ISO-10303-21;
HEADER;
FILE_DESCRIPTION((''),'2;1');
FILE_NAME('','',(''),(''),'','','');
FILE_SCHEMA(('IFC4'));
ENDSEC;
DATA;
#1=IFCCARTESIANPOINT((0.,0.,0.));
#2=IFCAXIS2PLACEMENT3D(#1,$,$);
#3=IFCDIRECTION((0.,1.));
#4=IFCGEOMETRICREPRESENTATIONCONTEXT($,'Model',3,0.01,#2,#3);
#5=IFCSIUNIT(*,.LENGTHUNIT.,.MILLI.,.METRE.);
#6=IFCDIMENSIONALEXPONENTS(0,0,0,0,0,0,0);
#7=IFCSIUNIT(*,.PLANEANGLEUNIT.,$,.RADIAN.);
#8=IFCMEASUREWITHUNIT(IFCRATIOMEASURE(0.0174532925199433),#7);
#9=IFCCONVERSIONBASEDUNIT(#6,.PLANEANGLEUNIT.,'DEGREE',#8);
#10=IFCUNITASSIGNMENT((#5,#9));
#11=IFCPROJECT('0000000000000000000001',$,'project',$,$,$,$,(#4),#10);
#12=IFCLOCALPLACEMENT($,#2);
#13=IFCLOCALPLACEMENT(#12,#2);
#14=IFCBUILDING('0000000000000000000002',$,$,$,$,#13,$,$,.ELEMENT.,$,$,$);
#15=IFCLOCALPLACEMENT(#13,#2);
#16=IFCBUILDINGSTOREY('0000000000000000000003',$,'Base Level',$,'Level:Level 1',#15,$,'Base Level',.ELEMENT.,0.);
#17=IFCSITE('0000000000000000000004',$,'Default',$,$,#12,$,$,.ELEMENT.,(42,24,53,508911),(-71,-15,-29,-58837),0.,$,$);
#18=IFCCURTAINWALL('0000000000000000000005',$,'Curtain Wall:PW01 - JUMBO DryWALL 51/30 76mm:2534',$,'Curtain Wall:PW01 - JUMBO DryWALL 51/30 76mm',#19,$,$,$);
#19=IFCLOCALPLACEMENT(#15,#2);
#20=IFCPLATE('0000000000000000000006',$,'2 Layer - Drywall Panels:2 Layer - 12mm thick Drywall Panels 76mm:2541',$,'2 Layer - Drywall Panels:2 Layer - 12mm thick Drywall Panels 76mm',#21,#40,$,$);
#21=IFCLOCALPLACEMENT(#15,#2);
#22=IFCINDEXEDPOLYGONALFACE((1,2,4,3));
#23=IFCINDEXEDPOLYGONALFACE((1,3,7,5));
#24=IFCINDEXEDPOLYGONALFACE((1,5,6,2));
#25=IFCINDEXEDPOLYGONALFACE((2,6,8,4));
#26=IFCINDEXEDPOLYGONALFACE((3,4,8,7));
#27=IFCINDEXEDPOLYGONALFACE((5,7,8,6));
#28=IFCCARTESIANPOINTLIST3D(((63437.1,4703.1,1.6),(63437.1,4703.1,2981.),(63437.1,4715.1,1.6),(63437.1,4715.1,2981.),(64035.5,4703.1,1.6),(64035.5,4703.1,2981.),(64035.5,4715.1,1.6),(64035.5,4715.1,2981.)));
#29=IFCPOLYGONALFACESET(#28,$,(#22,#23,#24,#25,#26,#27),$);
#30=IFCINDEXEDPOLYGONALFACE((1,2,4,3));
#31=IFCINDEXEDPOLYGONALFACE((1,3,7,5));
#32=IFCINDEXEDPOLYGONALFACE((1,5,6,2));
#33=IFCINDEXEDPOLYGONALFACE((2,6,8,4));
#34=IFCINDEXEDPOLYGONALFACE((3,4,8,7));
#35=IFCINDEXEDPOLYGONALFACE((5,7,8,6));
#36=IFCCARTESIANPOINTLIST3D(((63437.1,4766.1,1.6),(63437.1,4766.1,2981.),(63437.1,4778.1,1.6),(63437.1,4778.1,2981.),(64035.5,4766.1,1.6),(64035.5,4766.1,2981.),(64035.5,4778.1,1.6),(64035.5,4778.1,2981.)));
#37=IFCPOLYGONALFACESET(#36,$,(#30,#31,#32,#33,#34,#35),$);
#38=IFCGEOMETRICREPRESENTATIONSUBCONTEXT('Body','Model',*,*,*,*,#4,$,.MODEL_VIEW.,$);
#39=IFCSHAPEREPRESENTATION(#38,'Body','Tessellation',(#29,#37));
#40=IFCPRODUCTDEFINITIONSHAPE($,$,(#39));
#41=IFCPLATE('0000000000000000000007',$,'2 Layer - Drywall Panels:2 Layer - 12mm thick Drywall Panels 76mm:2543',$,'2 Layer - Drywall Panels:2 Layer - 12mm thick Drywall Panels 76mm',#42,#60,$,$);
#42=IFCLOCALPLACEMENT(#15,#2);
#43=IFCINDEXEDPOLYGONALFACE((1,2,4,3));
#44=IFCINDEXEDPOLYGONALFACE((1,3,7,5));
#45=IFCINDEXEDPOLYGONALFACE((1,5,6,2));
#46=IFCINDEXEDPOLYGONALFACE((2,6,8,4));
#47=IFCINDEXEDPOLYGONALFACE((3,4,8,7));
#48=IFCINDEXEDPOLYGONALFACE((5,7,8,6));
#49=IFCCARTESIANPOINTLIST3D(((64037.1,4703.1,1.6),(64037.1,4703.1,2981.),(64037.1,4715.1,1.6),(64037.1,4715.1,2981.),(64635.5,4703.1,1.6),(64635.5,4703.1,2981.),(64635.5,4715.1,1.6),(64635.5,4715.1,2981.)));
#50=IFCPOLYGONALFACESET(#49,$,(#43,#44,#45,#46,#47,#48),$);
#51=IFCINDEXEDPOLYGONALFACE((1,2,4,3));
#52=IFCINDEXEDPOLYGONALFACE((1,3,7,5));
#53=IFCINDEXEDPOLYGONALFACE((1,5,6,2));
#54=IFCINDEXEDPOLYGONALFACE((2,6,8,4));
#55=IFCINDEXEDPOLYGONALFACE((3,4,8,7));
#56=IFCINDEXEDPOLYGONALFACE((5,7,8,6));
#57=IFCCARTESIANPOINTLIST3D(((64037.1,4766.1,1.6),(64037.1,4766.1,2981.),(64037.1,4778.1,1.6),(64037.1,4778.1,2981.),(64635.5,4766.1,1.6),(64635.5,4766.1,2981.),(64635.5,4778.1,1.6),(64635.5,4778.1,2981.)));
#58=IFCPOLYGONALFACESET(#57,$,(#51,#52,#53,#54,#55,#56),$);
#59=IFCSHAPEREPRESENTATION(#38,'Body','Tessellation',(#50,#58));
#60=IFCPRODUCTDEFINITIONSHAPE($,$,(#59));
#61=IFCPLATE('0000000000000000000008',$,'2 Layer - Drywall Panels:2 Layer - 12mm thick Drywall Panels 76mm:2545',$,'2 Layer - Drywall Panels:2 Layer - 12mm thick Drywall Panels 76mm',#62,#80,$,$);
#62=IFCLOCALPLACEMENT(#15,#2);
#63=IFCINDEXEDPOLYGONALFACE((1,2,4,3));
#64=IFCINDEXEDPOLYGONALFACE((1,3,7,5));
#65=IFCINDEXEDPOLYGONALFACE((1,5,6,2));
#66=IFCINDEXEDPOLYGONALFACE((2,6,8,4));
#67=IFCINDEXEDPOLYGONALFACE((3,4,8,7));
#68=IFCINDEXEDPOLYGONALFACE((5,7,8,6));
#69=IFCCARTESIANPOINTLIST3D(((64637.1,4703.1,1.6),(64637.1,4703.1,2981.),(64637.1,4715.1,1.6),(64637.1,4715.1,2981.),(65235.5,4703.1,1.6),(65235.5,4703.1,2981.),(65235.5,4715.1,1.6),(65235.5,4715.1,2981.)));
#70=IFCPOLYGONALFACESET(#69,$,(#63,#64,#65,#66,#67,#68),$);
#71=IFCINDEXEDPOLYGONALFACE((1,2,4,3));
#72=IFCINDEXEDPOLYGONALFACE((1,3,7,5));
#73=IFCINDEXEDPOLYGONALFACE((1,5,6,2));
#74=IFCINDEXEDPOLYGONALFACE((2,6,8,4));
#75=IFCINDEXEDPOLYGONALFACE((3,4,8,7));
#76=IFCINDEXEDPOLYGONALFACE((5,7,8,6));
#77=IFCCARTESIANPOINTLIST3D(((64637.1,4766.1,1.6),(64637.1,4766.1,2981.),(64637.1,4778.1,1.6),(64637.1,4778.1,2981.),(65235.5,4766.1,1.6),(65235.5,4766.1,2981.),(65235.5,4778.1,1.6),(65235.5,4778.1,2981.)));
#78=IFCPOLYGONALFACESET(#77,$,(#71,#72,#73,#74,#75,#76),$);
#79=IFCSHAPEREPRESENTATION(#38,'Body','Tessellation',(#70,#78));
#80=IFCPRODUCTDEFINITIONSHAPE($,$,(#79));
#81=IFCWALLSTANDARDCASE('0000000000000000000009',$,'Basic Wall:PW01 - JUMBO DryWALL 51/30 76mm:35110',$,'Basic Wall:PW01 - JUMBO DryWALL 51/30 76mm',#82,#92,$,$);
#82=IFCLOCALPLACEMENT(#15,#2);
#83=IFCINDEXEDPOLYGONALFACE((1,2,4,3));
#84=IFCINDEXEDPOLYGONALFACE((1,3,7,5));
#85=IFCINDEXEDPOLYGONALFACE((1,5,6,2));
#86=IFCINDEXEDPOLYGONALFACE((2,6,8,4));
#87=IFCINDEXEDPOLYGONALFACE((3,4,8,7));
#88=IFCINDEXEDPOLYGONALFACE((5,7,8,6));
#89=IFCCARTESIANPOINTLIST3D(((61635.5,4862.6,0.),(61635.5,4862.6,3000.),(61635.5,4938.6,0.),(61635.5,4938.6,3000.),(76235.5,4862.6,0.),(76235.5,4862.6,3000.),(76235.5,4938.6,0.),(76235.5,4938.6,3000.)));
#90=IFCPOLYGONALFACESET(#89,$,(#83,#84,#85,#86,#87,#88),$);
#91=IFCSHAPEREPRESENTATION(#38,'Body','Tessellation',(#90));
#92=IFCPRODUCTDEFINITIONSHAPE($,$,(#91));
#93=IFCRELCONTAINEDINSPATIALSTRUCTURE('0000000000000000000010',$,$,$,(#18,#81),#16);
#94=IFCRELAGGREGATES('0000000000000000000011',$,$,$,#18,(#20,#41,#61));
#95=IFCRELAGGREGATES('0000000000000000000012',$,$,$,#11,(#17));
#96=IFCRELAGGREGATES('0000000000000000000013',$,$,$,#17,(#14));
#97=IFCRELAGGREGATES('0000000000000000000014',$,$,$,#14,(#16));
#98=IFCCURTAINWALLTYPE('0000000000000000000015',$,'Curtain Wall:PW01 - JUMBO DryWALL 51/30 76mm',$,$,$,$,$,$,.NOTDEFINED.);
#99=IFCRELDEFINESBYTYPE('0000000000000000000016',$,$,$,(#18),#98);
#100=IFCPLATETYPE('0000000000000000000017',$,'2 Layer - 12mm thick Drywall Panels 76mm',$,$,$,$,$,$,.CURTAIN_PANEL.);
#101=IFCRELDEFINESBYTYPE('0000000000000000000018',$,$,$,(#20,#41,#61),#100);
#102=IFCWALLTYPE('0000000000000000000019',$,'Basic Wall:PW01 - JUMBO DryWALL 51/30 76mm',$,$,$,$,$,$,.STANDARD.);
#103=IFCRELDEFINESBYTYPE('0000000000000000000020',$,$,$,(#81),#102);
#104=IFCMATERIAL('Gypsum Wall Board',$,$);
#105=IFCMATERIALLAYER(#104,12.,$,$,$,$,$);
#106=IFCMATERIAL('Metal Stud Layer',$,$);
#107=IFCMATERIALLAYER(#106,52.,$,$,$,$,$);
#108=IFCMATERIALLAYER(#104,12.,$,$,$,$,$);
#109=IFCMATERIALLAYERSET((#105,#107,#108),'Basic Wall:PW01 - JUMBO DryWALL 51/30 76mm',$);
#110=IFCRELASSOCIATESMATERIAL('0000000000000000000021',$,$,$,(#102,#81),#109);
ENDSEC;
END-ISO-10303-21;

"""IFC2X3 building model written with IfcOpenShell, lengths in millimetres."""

from ifc_helpers import new_model, entity, si_unit, converted_unit, direction, frame, frame_2d, origin, origin_2d_with_axis, place, context, subcontext, project, spatial, rectangle, extrude, source, transform, mapped, material, layer, layer_set, layer_usage, type_object, type_shapes, element, aggregate, save


model = new_model("IFC2X3")

# Units and contexts
model_context = context("Model", 3, precision=0.01, world=origin(), true_north=direction((0.0, 1.0)))
body_context = subcontext(model_context, "Body", "Model", "MODEL_VIEW")
ifc_project = project(units=[si_unit("LENGTHUNIT", "METRE", prefix="MILLI"), converted_unit("PLANEANGLEUNIT", "DEGREE", entity("IfcRatioMeasure", 0.0174532925199433), si_unit("PLANEANGLEUNIT", "RADIAN"), dimensions=[0, 0, 0, 0, 0, 0, 0])], contexts=[model_context])

# Site, building, storey
site_placement = place(None, origin())
site = spatial("IfcSite", under=ifc_project, at=site_placement, Name="Default", CompositionType="ELEMENT", RefLatitude=(42, 24, 53, 508911), RefLongitude=(-71, -15, -29, -58837), RefElevation=0.0)
building_placement = place(site_placement, origin())
building = spatial("IfcBuilding", under=site, at=building_placement, CompositionType="ELEMENT")
storey_placement = place(building_placement, origin())
storey = spatial("IfcBuildingStorey", under=building, at=storey_placement, Name="Base Level", ObjectType="Level:Level 1", LongName="Base Level", CompositionType="ELEMENT", Elevation=0.0)

# Curtain wall, plates
curtain_wall_type = type_object("IfcCurtainWallType", Name="Curtain Wall:PW01 - JUMBO DryWALL 51/30 76mm", PredefinedType="NOTDEFINED")
curtain_wall_placement = place(building_placement, origin())
curtain_wall = element("IfcCurtainWall", 1, at=curtain_wall_placement, inside=storey, type_object=curtain_wall_type, Name="Curtain Wall:PW01 - JUMBO DryWALL 51/30 76mm:2534", ObjectType="Curtain Wall:PW01 - JUMBO DryWALL 51/30 76mm")
plate_type = type_object("IfcPlateType", Name="2 Layer - 12mm thick Drywall Panels 76mm", PredefinedType="CURTAIN_PANEL")
shared_shape_1 = source(origin(), body_context, "Body", "SweptSolid", [
    extrude(rectangle(XDim=598.4, YDim=12.0, at=origin_2d_with_axis()), frame((0.0, -31.5, 0.0), z_axis=(0.0, 0.0, 1.0), x_axis=(-1.0, 0.0, 0.0)), (0.0, 0.0, 1.0), 2979.4),
    extrude(rectangle(XDim=12.0, YDim=598.4, at=frame_2d((0.0, 0.0), x_axis=(1.0, 0.0))), frame((0.0, 31.5, 0.0), z_axis=(0.0, 0.0, 1.0), x_axis=(0.0, 1.0, 0.0)), (0.0, 0.0, 1.0), 2979.4),
])
type_shapes(plate_type, [shared_shape_1])
plate_1_placement = place(curtain_wall_placement, frame((63736.3, 4740.6, 1.6)))
plate_1 = element("IfcPlate", 2, at=plate_1_placement, type_object=plate_type, Name="2 Layer - Drywall Panels:2 Layer - 12mm thick Drywall Panels 76mm:2541", ObjectType="2 Layer - Drywall Panels:2 Layer - 12mm thick Drywall Panels 76mm", context=body_context, shape_type="MappedRepresentation", body=[
    mapped(shared_shape_1, transform((0.0, 0.0, 0.0), scale=1.0)),
])
plate_2_placement = place(curtain_wall_placement, frame((64336.3, 4740.6, 1.6)))
plate_2 = element("IfcPlate", 3, at=plate_2_placement, type_object=plate_type, Name="2 Layer - Drywall Panels:2 Layer - 12mm thick Drywall Panels 76mm:2543", ObjectType="2 Layer - Drywall Panels:2 Layer - 12mm thick Drywall Panels 76mm", context=body_context, shape_type="MappedRepresentation", body=[
    mapped(shared_shape_1, transform((0.0, 0.0, 0.0), scale=1.0)),
])
plate_3_placement = place(curtain_wall_placement, frame((64936.3, 4740.6, 1.6)))
plate_3 = element("IfcPlate", 4, at=plate_3_placement, type_object=plate_type, Name="2 Layer - Drywall Panels:2 Layer - 12mm thick Drywall Panels 76mm:2545", ObjectType="2 Layer - Drywall Panels:2 Layer - 12mm thick Drywall Panels 76mm", context=body_context, shape_type="MappedRepresentation", body=[
    mapped(shared_shape_1, transform((0.0, 0.0, 0.0), scale=1.0)),
])
aggregate(curtain_wall, [plate_1, plate_2, plate_3])

# Wall
ifc_material_1 = material(Name="Gypsum Wall Board")
ifc_layer_1 = layer(ifc_material_1, 12.0)
ifc_material_2 = material(Name="Metal Stud Layer")
ifc_layer_2 = layer(ifc_material_2, 52.0)
ifc_layer_3 = layer(ifc_material_1, 12.0)
ifc_layer_set = layer_set([ifc_layer_1, ifc_layer_2, ifc_layer_3], Name="Basic Wall:PW01 - JUMBO DryWALL 51/30 76mm")
ifc_layer_usage = layer_usage(ifc_layer_set, "AXIS2", "NEGATIVE", 38.0)
wall_type = type_object("IfcWallType", Name="Basic Wall:PW01 - JUMBO DryWALL 51/30 76mm", PredefinedType="STANDARD", material=ifc_layer_set)
wall_placement = place(storey_placement, frame((61635.5, 4900.6, 0.0)))
element("IfcWallStandardCase", 5, at=wall_placement, inside=storey, type_object=wall_type, material=ifc_layer_usage, Name="Basic Wall:PW01 - JUMBO DryWALL 51/30 76mm:35110", ObjectType="Basic Wall:PW01 - JUMBO DryWALL 51/30 76mm", context=body_context, shape_type="SweptSolid", body=[
    extrude(rectangle(XDim=14600.0, YDim=76.0, at=frame_2d((7300.0, 0.0), x_axis=(-1.0, 0.0))), origin(), (0.0, 0.0, 1.0), 3000.0),
])

save(model, "model.ifc")
